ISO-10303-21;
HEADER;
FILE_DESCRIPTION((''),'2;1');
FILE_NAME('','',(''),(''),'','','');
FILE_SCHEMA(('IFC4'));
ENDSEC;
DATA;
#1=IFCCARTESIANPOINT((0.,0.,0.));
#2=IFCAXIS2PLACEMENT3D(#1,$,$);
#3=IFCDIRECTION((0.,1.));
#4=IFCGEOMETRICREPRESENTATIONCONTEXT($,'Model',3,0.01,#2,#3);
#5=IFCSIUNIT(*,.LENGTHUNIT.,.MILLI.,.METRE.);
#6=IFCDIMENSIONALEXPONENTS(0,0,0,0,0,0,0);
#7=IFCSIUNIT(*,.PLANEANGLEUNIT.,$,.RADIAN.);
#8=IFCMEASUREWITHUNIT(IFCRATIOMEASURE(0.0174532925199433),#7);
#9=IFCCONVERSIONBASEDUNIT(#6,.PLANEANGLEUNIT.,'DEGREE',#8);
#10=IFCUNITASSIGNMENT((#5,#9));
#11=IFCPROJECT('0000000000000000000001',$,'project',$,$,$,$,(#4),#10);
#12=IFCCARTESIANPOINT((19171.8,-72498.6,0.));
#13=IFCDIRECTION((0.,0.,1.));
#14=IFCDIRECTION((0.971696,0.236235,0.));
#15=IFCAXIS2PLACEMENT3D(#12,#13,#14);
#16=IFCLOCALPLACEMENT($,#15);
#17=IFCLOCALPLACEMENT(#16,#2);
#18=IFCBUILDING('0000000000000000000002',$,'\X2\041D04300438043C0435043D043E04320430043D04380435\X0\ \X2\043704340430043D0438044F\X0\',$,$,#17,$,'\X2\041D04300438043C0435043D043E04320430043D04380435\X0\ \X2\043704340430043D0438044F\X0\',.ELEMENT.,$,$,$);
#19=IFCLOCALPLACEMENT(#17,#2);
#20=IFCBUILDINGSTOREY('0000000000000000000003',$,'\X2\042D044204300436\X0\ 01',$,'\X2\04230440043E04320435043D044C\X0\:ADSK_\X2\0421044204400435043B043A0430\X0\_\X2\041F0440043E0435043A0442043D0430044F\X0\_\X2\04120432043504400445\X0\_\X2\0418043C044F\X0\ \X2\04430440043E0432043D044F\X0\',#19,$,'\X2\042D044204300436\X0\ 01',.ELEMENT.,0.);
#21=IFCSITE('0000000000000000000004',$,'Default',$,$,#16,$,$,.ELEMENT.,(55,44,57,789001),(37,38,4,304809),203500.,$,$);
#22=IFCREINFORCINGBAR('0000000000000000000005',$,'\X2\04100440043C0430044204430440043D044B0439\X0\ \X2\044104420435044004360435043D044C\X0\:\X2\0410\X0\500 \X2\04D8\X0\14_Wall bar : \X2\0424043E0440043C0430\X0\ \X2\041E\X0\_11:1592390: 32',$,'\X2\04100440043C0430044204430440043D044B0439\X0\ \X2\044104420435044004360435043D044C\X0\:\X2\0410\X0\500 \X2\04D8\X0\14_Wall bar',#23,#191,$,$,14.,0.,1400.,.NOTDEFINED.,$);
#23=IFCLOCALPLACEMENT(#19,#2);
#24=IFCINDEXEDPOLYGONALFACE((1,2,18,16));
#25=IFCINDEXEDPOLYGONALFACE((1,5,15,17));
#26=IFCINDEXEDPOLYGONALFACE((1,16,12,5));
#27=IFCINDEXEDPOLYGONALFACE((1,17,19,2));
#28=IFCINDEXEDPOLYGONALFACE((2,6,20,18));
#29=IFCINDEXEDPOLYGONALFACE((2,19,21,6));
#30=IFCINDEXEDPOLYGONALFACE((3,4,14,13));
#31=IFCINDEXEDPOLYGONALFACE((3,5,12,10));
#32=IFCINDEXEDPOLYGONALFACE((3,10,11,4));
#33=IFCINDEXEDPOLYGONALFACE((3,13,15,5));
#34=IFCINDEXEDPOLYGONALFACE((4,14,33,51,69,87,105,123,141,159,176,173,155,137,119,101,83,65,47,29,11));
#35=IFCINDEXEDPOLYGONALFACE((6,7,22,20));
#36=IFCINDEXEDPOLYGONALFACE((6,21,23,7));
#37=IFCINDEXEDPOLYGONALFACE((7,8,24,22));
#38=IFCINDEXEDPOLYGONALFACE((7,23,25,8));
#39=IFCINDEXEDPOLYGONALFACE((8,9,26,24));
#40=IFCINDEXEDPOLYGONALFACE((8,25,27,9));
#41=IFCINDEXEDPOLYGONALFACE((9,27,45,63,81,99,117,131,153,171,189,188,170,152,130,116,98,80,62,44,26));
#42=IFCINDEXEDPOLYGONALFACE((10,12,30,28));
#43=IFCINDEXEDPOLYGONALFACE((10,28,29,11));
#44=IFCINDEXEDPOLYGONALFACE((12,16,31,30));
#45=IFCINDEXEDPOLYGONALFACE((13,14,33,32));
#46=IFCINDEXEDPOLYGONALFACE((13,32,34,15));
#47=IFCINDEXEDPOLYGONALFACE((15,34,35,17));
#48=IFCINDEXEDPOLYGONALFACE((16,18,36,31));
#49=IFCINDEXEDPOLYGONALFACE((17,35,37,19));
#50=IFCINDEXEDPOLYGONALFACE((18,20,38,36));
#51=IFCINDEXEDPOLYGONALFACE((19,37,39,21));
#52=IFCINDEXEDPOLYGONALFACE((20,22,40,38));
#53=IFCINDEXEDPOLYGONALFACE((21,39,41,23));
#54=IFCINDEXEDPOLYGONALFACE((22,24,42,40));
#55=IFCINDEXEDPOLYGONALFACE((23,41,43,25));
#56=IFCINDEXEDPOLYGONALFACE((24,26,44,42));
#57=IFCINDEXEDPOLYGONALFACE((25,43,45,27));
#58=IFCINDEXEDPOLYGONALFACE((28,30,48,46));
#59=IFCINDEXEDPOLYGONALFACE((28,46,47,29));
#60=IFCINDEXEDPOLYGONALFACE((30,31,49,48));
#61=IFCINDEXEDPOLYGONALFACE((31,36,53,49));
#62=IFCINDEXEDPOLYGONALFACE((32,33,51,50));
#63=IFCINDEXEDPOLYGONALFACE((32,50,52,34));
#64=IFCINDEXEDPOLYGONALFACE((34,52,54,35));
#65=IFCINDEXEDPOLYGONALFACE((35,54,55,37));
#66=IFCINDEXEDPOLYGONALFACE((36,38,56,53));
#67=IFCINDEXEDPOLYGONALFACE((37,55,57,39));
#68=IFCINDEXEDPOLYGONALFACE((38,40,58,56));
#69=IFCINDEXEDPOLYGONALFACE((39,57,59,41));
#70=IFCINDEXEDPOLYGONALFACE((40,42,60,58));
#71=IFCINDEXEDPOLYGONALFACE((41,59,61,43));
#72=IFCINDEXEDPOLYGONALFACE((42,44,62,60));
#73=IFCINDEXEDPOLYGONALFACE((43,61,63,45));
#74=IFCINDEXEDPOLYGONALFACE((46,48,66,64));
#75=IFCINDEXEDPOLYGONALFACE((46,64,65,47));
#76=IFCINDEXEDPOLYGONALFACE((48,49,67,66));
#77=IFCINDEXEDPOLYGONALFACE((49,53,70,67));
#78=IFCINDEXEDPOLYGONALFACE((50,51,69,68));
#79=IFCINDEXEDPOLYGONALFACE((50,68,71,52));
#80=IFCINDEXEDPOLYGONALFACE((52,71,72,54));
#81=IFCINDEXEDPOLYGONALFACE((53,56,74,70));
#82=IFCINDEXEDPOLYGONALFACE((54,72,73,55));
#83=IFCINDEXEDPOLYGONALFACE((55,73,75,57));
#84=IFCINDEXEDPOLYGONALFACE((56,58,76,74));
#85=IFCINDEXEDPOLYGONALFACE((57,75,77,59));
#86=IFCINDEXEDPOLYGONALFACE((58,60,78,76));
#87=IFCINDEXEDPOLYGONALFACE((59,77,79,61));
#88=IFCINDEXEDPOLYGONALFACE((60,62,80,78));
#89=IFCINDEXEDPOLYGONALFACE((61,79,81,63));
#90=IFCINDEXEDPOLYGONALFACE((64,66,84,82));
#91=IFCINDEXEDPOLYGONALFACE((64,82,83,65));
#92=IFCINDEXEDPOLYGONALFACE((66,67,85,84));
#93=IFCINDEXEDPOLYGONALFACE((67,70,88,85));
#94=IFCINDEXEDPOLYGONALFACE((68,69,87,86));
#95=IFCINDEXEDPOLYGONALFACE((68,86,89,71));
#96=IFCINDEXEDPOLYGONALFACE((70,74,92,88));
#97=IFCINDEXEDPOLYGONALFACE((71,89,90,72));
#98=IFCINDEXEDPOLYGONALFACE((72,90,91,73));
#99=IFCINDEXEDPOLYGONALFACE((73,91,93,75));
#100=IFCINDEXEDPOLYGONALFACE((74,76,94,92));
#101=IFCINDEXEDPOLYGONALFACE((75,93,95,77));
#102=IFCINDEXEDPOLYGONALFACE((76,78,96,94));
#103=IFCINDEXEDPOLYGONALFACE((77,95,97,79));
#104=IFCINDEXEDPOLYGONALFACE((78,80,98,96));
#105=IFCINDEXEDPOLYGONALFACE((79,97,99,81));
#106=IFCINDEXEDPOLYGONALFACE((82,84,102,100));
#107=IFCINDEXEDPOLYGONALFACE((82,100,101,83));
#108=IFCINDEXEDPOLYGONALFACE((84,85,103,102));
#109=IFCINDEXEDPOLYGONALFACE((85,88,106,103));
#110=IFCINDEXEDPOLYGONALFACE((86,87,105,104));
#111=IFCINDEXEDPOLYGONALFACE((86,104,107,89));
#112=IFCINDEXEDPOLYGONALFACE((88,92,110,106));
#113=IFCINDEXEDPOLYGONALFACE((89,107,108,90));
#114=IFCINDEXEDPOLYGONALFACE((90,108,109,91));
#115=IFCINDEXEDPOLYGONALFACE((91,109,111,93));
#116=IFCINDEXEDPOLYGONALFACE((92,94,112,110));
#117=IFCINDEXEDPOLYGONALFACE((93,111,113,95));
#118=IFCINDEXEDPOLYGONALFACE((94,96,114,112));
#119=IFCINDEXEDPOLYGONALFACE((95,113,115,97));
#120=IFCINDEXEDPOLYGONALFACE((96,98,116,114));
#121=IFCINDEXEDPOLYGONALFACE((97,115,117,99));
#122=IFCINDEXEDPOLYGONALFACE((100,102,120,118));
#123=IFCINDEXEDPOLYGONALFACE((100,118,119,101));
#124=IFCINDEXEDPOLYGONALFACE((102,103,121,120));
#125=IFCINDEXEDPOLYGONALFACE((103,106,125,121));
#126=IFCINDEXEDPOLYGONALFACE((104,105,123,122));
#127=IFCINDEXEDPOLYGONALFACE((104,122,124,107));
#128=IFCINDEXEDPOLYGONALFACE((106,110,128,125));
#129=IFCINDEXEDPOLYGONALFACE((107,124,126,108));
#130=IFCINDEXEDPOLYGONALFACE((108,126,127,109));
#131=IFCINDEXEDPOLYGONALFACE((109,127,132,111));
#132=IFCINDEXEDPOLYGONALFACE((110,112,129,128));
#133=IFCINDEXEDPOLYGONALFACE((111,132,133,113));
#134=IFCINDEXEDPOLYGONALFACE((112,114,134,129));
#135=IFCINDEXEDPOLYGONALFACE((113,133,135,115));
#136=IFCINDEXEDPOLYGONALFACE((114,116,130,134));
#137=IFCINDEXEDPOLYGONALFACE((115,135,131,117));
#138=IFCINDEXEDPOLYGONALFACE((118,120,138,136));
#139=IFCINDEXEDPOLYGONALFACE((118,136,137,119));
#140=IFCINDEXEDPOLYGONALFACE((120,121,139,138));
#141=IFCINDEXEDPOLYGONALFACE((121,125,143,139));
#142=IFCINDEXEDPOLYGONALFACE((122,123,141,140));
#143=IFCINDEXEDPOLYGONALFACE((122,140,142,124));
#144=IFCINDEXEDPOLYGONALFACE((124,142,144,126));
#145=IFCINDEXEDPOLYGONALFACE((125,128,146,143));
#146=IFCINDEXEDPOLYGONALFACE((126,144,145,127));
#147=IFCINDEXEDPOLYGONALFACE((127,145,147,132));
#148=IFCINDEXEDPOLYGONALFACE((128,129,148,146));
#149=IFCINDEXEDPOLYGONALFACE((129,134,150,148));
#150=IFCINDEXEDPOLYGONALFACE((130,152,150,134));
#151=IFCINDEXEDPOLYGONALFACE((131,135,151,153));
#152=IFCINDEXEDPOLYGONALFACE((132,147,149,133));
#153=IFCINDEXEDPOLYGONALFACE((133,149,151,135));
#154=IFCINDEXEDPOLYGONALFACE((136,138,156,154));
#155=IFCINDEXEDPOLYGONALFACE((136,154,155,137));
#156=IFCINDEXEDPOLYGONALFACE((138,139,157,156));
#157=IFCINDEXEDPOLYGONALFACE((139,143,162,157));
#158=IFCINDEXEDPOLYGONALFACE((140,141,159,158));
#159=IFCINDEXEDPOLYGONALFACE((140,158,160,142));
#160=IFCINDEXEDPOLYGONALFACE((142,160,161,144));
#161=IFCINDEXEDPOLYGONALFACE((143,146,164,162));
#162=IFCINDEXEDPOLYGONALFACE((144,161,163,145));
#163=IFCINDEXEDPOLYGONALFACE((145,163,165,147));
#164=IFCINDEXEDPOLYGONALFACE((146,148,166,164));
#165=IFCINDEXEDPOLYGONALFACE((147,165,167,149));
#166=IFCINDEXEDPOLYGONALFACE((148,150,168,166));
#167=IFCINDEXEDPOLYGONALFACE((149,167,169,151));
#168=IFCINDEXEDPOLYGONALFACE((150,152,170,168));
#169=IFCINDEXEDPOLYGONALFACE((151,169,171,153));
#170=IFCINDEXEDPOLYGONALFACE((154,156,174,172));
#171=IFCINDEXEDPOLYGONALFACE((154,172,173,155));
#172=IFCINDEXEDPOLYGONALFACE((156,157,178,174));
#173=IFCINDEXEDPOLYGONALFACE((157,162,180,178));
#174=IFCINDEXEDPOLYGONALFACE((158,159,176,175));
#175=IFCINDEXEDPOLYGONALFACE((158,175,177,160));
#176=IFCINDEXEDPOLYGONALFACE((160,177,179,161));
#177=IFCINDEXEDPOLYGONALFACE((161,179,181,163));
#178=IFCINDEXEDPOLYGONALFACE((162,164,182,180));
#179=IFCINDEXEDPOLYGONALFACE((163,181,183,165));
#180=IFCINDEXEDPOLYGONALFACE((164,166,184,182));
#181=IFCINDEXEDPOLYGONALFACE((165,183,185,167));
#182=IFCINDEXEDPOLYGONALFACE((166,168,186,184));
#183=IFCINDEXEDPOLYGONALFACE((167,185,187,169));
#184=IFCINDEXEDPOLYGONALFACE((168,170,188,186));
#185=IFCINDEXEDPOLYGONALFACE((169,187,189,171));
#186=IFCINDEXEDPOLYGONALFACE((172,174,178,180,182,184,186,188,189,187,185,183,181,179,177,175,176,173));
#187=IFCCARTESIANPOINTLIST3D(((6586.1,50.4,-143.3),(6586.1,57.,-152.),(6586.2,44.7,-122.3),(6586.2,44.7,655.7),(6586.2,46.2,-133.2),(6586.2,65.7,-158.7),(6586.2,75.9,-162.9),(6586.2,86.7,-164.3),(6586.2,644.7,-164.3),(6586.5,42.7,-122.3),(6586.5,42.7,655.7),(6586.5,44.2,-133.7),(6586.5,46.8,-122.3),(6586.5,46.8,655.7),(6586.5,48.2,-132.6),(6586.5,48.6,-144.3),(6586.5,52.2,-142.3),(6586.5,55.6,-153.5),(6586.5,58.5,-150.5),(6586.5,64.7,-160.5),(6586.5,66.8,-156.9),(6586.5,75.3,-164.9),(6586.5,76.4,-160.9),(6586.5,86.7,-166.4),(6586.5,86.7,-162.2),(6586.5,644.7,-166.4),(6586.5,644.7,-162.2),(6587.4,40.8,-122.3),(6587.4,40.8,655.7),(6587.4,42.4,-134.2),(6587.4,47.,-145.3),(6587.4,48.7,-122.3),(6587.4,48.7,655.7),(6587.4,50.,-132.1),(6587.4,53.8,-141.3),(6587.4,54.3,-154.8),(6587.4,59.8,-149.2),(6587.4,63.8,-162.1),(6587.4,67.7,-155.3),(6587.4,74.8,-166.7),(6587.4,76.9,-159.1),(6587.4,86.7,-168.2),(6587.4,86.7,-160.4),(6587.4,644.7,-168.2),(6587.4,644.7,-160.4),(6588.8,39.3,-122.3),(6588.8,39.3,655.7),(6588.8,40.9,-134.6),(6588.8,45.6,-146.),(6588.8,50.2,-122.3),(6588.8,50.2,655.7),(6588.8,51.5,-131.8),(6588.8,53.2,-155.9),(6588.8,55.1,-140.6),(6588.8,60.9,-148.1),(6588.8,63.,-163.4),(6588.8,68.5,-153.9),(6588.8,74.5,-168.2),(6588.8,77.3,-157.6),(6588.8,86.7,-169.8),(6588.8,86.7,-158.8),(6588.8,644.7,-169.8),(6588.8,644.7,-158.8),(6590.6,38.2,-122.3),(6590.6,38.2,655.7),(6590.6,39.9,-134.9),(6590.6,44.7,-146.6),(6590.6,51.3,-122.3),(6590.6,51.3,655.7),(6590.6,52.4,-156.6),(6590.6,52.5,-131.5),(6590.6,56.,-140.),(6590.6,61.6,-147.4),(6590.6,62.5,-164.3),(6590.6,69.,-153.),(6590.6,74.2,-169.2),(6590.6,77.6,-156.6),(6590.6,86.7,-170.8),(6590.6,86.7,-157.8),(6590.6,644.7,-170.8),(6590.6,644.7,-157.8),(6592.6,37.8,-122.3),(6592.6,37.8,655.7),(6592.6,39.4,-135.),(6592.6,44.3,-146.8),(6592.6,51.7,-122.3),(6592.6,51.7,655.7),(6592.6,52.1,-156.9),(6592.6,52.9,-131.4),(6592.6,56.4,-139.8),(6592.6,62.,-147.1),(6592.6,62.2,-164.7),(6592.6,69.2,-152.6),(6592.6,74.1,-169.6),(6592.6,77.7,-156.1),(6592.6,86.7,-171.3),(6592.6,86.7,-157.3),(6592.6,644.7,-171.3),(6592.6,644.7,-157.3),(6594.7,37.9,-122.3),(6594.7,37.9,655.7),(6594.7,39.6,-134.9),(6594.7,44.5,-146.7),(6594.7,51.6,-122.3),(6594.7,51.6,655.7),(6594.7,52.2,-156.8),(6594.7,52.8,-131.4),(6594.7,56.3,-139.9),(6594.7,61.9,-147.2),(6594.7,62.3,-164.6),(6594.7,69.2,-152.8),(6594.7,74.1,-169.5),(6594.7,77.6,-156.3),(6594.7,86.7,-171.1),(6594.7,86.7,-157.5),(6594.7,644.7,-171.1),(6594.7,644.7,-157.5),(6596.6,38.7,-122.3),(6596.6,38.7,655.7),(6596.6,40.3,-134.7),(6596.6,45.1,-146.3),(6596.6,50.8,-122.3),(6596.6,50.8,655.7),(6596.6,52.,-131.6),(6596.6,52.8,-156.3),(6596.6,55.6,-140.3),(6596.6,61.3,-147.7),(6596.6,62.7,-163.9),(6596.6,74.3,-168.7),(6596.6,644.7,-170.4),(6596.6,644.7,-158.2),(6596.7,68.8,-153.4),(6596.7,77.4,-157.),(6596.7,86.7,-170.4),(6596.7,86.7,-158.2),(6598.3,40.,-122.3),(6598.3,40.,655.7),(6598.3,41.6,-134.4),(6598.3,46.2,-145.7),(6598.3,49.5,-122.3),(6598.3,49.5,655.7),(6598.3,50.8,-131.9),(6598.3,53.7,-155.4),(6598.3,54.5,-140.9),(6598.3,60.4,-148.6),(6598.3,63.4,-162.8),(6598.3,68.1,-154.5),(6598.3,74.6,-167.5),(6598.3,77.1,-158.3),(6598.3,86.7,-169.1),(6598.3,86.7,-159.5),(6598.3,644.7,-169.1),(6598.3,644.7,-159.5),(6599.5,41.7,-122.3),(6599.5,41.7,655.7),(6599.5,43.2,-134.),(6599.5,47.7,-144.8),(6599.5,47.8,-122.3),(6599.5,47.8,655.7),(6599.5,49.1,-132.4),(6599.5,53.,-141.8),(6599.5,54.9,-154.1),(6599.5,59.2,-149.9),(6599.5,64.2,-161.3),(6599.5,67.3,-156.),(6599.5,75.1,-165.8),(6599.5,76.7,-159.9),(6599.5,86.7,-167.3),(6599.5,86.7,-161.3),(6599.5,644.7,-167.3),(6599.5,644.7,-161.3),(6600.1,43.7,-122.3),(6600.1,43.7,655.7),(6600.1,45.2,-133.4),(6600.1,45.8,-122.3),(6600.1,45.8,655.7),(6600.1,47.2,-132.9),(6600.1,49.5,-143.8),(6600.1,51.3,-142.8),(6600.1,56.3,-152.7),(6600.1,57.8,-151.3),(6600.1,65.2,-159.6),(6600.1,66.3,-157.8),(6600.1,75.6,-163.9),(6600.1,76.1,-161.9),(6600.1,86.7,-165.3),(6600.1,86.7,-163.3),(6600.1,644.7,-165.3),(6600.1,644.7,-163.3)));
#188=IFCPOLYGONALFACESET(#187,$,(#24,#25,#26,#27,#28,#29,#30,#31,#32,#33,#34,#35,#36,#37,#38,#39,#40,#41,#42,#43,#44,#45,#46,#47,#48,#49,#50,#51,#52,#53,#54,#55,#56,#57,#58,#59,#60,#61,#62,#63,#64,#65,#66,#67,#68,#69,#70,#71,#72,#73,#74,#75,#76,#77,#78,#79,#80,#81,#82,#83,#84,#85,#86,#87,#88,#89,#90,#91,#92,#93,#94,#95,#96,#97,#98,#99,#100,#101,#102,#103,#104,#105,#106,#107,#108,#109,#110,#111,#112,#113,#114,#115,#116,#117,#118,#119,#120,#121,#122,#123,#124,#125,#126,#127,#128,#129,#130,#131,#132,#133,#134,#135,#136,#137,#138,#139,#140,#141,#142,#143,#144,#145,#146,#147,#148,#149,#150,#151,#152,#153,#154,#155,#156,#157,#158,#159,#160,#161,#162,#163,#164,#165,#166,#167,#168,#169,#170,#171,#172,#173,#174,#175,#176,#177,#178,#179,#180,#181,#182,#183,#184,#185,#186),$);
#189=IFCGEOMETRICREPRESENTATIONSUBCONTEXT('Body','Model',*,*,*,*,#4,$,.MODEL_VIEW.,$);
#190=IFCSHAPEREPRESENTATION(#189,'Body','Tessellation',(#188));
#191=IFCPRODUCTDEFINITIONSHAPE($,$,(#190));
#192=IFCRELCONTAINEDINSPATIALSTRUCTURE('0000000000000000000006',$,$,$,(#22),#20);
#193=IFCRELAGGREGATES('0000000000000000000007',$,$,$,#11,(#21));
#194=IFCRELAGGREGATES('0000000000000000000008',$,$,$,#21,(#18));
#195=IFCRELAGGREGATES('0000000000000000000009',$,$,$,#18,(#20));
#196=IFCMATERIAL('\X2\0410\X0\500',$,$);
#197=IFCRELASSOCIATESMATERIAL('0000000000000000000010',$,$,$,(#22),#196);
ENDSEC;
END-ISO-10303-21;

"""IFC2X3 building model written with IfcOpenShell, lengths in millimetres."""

from ifc_helpers import new_model, entity, si_unit, converted_unit, direction, frame, origin, place, context, subcontext, project, spatial, material, element, save


model = new_model("IFC2X3")

# Units and contexts
model_context = context("Model", 3, precision=0.01, world=origin(), true_north=direction((0.0, 1.0)))
body_context = subcontext(model_context, "Body", "Model", "MODEL_VIEW")
ifc_project = project(units=[si_unit("LENGTHUNIT", "METRE", prefix="MILLI"), converted_unit("PLANEANGLEUNIT", "DEGREE", entity("IfcRatioMeasure", 0.0174532925199433), si_unit("PLANEANGLEUNIT", "RADIAN"), dimensions=[0, 0, 0, 0, 0, 0, 0])], contexts=[model_context])

# Site, building, storey
site_placement = place(None, frame((19171.8, -72498.6, 0.0), z_axis=(0.0, 0.0, 1.0), x_axis=(0.971696, 0.236235, 0.0)))
site = spatial("IfcSite", under=ifc_project, at=site_placement, Name="Default", CompositionType="ELEMENT", RefLatitude=(55, 44, 57, 789001), RefLongitude=(37, 38, 4, 304809), RefElevation=203500.0)
building_placement = place(site_placement, origin())
building = spatial("IfcBuilding", under=site, at=building_placement, Name="Наименование здания", LongName="Наименование здания", CompositionType="ELEMENT")
storey_placement = place(building_placement, origin())
storey = spatial("IfcBuildingStorey", under=building, at=storey_placement, Name="Этаж 01", ObjectType="Уровень:ADSK_Стрелка_Проектная_Вверх_Имя уровня", LongName="Этаж 01", CompositionType="ELEMENT", Elevation=0.0)

# Reinforcing bar
ifc_material = material(Name="А500")
placement = place(storey_placement, origin())
element("IfcReinforcingBar", 1, at=placement, inside=storey, material=ifc_material, Name="Арматурный стержень:А500 Ә14_Wall bar : Форма О_11:1592390: 32", ObjectType="Арматурный стержень:А500 Ә14_Wall bar", BarLength=1400.0, BarRole="NOTDEFINED", CrossSectionArea=0.0, NominalDiameter=14.0, context=body_context, shape_type="AdvancedSweptSolid", body=[
    entity("IfcSweptDiskSolid", entity("IfcCompositeCurve", [entity("IfcCompositeCurveSegment", "CONTINUOUS", True, entity("IfcPolyline", [entity("IfcCartesianPoint", [6593.1, 44.7, 655.7]), entity("IfcCartesianPoint", [6593.1, 44.7, -122.3])])), entity("IfcCompositeCurveSegment", "CONTINUOUS", True, entity("IfcTrimmedCurve", entity("IfcCircle", entity("IfcAxis2Placement3D", entity("IfcCartesianPoint", [6593.1, 86.7, -122.3]), entity("IfcDirection", [1.0, 0.0, 0.0]), entity("IfcDirection", [0.0, 0.0, -1.0])), 42.0), [entity("IfcParameterValue", 270.0)], [entity("IfcParameterValue", 360.0)], True, "PARAMETER")), entity("IfcCompositeCurveSegment", "CONTINUOUS", True, entity("IfcPolyline", [entity("IfcCartesianPoint", [6593.1, 86.7, -164.3]), entity("IfcCartesianPoint", [6593.1, 644.7, -164.3])]))], False), 7.0, None, 0.0, 92.0),
])

save(model, "model.ifc")
